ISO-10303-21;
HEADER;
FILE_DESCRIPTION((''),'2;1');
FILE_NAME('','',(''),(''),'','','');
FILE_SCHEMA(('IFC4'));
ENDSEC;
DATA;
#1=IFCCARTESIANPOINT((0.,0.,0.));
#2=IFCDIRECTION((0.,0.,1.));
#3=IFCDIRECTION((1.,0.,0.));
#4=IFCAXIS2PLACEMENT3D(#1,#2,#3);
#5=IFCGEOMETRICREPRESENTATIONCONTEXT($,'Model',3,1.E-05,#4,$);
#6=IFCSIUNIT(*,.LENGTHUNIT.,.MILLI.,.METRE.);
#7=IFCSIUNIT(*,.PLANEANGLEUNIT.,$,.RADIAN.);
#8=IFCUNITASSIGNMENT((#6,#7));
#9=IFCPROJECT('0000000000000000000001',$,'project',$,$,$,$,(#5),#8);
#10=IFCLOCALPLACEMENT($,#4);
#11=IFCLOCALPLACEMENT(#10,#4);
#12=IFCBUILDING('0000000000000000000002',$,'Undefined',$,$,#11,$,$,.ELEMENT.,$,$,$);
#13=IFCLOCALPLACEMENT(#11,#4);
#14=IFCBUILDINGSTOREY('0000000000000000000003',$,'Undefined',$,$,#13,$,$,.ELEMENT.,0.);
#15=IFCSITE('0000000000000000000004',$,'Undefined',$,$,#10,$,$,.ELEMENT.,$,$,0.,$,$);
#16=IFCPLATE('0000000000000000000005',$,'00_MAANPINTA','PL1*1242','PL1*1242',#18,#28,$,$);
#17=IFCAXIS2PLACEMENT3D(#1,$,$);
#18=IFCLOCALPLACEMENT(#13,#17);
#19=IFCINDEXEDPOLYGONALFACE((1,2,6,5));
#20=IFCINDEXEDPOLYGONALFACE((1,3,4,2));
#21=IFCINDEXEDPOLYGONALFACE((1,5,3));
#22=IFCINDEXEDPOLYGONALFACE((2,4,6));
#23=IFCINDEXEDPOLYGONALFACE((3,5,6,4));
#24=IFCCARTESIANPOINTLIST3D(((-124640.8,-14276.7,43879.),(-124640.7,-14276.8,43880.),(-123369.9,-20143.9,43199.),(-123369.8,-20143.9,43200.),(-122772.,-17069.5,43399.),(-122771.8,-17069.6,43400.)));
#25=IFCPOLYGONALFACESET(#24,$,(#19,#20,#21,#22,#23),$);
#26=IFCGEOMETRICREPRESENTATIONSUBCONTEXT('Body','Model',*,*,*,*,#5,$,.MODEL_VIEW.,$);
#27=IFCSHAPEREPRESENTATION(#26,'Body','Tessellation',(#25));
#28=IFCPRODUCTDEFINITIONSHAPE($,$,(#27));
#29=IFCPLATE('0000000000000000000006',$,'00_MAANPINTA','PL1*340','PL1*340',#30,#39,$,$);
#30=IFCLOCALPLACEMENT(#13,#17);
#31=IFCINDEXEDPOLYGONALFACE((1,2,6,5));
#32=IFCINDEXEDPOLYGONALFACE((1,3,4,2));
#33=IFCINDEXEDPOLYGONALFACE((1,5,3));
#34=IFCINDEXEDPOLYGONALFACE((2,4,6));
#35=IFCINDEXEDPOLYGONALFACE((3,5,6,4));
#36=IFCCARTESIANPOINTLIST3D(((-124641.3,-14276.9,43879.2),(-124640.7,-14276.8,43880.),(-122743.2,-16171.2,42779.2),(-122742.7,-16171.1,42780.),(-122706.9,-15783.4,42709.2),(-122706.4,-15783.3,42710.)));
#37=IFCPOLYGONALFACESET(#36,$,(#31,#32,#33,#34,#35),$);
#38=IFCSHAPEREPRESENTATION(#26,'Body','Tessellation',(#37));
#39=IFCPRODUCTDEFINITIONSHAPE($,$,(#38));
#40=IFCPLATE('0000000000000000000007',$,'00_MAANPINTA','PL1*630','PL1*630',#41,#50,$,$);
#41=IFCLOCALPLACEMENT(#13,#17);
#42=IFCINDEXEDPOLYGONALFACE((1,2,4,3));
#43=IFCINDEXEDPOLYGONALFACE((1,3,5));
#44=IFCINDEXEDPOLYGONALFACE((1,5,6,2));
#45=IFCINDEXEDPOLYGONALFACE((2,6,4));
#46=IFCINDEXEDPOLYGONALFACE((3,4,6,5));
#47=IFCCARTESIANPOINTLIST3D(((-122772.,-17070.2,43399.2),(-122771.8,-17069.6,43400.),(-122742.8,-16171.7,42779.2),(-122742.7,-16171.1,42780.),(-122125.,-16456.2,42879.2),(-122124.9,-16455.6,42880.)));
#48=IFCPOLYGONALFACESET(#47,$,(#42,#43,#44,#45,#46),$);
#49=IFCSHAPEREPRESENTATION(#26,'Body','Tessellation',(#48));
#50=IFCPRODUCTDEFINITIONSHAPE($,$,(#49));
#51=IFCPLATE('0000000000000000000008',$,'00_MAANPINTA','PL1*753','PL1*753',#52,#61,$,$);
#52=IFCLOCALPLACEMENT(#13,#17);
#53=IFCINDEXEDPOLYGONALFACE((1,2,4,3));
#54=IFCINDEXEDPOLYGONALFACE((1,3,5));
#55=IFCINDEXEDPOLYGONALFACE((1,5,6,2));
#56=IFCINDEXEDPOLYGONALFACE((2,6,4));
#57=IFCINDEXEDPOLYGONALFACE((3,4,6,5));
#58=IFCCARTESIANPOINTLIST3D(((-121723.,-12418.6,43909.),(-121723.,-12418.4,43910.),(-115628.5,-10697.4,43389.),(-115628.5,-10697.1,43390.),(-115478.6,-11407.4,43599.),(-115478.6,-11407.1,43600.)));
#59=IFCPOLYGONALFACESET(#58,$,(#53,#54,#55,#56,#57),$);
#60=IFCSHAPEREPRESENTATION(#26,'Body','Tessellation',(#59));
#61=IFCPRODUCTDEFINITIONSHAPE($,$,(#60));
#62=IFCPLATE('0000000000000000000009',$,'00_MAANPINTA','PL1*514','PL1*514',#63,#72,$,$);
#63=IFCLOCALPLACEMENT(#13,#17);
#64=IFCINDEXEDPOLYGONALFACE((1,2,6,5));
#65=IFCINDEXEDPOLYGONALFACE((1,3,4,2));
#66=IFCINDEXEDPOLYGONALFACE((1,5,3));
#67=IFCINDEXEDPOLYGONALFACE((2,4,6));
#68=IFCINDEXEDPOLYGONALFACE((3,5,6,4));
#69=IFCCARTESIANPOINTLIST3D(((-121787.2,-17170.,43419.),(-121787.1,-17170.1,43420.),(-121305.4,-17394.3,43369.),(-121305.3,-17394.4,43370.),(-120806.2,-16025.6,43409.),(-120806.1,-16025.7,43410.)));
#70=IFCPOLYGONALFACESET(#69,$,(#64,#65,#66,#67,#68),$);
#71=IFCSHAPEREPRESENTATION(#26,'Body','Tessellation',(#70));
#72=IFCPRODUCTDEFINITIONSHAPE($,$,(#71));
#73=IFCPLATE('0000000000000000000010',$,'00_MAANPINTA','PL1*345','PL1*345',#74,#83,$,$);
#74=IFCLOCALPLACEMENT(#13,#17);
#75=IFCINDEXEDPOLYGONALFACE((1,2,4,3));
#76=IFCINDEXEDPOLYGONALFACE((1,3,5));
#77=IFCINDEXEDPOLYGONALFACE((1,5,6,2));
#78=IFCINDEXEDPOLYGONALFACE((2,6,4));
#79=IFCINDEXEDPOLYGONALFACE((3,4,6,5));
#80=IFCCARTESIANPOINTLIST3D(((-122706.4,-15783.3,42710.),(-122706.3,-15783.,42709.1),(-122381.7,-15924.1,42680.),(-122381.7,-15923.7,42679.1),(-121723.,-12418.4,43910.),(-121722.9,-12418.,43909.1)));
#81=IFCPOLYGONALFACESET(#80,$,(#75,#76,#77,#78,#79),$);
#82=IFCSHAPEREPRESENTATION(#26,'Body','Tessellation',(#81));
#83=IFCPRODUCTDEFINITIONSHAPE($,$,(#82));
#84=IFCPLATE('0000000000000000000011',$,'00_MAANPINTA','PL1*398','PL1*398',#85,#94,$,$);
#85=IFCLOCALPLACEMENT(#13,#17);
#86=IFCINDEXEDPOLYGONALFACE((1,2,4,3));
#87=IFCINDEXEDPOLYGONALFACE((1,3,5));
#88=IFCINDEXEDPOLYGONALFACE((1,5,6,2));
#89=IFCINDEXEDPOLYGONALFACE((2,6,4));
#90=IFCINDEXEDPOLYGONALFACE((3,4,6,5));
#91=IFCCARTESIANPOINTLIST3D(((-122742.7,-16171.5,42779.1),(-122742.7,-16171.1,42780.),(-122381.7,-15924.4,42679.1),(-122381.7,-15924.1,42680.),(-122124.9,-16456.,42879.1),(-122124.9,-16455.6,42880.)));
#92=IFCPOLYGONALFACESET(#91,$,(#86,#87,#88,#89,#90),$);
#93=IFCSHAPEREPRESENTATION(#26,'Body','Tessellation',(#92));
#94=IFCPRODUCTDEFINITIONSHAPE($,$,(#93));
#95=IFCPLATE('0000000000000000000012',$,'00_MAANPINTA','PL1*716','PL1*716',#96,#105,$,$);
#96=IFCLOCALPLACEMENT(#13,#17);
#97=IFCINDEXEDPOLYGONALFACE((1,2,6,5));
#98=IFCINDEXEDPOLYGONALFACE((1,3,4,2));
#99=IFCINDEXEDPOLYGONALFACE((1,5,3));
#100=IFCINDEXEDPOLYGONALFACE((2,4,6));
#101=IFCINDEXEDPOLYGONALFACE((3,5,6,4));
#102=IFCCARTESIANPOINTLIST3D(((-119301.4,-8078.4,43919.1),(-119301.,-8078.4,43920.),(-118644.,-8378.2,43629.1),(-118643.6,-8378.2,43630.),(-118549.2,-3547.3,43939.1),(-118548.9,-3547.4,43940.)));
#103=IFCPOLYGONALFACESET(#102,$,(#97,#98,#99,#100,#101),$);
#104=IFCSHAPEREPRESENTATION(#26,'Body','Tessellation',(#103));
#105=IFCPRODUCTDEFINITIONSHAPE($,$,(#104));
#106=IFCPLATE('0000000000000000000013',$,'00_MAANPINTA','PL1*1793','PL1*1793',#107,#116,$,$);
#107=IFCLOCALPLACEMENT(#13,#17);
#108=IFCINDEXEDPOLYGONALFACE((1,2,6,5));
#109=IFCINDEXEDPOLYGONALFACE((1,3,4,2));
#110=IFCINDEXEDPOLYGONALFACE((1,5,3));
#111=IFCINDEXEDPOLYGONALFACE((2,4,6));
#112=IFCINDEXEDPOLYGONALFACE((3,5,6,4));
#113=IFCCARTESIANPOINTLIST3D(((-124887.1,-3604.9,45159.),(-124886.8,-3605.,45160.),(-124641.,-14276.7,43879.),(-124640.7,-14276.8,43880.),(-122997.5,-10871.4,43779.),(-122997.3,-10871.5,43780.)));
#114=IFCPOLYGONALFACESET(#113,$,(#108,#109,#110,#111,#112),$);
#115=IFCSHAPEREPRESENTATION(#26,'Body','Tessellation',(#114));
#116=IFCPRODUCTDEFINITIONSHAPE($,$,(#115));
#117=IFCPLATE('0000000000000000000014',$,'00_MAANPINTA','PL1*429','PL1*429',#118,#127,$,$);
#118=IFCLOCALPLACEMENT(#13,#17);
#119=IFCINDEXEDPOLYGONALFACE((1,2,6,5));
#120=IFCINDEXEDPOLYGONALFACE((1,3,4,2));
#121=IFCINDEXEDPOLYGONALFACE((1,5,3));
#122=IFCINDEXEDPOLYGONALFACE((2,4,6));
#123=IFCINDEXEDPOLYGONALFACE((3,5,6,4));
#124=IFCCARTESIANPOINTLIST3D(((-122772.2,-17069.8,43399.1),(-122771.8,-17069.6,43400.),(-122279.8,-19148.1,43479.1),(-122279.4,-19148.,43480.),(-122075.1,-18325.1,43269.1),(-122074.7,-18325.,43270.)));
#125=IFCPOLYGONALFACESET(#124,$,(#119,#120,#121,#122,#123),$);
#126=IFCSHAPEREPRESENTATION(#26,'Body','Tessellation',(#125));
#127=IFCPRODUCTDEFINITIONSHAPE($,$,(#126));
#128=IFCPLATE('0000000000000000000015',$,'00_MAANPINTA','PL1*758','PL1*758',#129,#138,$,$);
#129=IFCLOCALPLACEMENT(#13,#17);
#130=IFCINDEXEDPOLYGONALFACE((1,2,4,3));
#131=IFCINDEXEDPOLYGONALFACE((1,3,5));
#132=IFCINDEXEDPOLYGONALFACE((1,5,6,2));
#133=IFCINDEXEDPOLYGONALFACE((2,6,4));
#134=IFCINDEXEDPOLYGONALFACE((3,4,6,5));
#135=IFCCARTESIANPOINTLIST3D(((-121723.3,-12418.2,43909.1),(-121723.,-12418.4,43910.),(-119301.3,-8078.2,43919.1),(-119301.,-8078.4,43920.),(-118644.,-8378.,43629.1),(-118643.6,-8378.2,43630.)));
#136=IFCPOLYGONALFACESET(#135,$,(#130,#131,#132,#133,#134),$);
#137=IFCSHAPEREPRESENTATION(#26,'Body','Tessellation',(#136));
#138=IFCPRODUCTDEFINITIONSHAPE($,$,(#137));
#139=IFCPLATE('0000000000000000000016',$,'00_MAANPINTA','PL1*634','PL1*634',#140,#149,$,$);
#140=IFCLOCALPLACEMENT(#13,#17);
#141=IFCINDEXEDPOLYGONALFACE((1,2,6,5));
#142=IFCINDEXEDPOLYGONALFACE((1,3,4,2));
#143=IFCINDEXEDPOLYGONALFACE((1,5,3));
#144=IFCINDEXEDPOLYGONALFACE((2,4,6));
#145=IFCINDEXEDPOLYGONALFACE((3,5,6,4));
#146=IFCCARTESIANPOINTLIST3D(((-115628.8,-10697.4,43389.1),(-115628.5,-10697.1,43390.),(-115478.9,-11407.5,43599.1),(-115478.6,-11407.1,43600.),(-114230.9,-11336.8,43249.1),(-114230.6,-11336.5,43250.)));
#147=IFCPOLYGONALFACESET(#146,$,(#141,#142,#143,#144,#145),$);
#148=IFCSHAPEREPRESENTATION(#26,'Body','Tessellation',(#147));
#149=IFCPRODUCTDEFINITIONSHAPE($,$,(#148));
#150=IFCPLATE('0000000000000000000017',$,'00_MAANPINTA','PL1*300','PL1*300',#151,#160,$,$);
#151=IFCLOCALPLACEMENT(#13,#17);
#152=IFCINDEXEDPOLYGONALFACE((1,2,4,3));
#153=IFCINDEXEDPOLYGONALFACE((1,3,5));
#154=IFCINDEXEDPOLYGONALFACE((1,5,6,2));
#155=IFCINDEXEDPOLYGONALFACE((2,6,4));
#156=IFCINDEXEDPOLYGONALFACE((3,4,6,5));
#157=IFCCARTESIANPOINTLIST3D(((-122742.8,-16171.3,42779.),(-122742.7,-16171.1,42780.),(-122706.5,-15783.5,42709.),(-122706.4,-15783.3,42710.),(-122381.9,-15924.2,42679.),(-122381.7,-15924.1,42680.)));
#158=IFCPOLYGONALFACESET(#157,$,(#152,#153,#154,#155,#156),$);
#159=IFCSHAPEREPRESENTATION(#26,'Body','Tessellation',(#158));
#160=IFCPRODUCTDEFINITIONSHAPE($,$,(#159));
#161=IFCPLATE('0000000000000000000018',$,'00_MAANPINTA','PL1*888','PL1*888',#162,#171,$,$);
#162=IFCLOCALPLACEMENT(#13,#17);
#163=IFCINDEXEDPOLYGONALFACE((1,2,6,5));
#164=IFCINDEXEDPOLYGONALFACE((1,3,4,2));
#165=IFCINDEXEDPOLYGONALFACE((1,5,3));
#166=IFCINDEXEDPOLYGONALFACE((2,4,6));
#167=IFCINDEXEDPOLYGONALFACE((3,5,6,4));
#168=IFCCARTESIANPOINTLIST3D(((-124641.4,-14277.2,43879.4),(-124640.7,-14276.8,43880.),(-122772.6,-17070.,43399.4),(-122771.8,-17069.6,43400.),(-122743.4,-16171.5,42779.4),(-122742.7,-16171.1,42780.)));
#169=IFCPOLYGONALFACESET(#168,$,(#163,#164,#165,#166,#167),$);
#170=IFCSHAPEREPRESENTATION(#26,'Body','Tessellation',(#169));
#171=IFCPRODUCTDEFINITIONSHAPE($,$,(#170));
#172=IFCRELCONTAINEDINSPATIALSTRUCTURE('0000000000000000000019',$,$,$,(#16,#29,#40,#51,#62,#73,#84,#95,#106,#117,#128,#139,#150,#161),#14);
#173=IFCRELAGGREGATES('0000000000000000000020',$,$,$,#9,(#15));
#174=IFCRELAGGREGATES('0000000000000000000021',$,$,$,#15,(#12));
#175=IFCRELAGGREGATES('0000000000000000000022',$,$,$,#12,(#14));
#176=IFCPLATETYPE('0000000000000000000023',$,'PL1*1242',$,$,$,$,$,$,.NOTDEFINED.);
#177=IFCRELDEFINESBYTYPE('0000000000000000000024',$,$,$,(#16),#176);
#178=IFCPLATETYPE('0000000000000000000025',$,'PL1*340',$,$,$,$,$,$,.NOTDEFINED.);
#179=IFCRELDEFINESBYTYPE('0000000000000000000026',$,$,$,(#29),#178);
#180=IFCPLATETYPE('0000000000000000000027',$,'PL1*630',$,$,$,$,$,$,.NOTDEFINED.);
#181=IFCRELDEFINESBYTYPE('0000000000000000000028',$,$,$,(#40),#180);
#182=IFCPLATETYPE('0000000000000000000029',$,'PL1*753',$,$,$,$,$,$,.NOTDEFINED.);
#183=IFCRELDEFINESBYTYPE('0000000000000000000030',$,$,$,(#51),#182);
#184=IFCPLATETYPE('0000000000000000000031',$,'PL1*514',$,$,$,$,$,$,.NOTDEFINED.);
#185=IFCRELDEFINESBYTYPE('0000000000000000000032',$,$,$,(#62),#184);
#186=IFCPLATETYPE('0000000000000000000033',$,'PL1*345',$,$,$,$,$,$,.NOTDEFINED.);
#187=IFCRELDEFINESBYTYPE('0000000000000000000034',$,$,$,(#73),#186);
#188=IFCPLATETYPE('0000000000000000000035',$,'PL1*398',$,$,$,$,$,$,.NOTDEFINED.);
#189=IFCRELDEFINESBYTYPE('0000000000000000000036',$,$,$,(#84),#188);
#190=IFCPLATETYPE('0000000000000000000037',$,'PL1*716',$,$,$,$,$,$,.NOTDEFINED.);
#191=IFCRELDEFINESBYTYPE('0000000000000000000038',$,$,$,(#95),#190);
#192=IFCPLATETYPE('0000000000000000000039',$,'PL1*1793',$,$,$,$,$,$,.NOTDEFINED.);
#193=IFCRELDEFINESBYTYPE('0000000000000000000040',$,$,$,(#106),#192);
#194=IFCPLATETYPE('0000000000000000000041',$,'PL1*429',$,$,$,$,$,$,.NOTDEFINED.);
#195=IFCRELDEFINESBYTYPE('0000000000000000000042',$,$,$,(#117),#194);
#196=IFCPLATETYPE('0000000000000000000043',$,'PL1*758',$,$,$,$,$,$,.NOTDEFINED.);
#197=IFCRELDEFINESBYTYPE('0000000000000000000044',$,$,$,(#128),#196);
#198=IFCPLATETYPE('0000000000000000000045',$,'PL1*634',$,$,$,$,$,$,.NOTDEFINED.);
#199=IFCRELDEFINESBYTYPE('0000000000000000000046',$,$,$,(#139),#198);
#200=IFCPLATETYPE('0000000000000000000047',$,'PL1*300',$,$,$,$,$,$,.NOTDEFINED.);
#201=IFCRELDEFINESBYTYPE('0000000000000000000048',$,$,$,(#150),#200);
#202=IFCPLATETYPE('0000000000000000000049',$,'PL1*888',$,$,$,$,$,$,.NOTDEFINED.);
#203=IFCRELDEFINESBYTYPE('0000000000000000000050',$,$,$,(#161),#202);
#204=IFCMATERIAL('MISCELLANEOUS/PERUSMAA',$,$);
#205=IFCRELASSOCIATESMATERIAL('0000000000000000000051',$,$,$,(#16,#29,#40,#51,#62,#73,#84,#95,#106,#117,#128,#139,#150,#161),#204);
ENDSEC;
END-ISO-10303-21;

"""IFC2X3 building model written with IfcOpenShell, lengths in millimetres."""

from ifc_helpers import new_model, si_unit, frame, origin_with_axes, place, context, subcontext, project, spatial, polyline, outline, extrude, material, type_object, element, save


model = new_model("IFC2X3")

# Units and contexts
model_context = context("Model", 3, precision=1e-05, world=origin_with_axes())
body_context = subcontext(model_context, "Body", "Model", "MODEL_VIEW")
ifc_project = project(units=[si_unit("LENGTHUNIT", "METRE", prefix="MILLI"), si_unit("PLANEANGLEUNIT", "RADIAN")], contexts=[model_context])

# Site, building, storey
site_placement = place(None, origin_with_axes())
site = spatial("IfcSite", under=ifc_project, at=site_placement, Name="Undefined", CompositionType="ELEMENT", RefElevation=0.0)
building_placement = place(site_placement, origin_with_axes())
building = spatial("IfcBuilding", under=site, at=building_placement, Name="Undefined", CompositionType="ELEMENT")
storey_placement = place(building_placement, origin_with_axes())
storey = spatial("IfcBuildingStorey", under=building, at=storey_placement, Name="Undefined", CompositionType="ELEMENT", Elevation=0.0)

# Plates
ifc_material = material(Name="MISCELLANEOUS/PERUSMAA")
plate_type_1 = type_object("IfcPlateType", Name="PL1*1242", PredefinedType="NOTDEFINED")
plate_1_placement = place(storey_placement, frame((-122771.9, -17069.6, 43399.5), z_axis=(-0.122262, 0.088093, -0.988581), x_axis=(-0.190543, -0.979608, -0.063729)))
element("IfcPlate", 1, at=plate_1_placement, inside=storey, type_object=plate_type_1, material=ifc_material, Name="00_MAANPINTA", Description="PL1*1242", ObjectType="PL1*1242", context=body_context, shape_type="SweptSolid", body=[
    extrude(outline(polyline([(0.0, 0.0), (3138.3, 0.0), (-2410.4, 2390.2), (0.0, 0.0)])), frame((0.0, 0.0, -0.5), z_axis=(0.0, 0.0, 1.0), x_axis=(1.0, 0.0, 0.0)), (0.0, 0.0, 1.0), 1.0),
])
plate_type_2 = type_object("IfcPlateType", Name="PL1*340", PredefinedType="NOTDEFINED")
plate_2_placement = place(storey_placement, frame((-124641.0, -14276.8, 43879.6), z_axis=(-0.568042, -0.094408, -0.817567), x_axis=(0.712031, -0.554551, -0.43068)))
element("IfcPlate", 2, at=plate_2_placement, inside=storey, type_object=plate_type_2, material=ifc_material, Name="00_MAANPINTA", Description="PL1*340", ObjectType="PL1*340", context=body_context, shape_type="SweptSolid", body=[
    extrude(outline(polyline([(0.0, 0.0), (2716.6, 0.0), (2875.7, 362.4), (0.0, 0.0)])), frame((0.0, 0.0, -0.5), z_axis=(0.0, 0.0, 1.0), x_axis=(1.0, 0.0, 0.0)), (0.0, 0.0, 1.0), 1.0),
])
plate_type_3 = type_object("IfcPlateType", Name="PL1*630", PredefinedType="NOTDEFINED")
plate_3_placement = place(storey_placement, frame((-122771.9, -17069.9, 43399.6), z_axis=(-0.125708, -0.560662, -0.818447), x_axis=(0.026719, 0.822779, -0.567733)))
element("IfcPlate", 3, at=plate_3_placement, inside=storey, type_object=plate_type_3, material=ifc_material, Name="00_MAANPINTA", Description="PL1*630", ObjectType="PL1*630", context=body_context, shape_type="SweptSolid", body=[
    extrude(outline(polyline([(0.0, 0.0), (1092.1, 0.0), (817.7, 630.3), (0.0, 0.0)])), frame((0.0, 0.0, -0.5), z_axis=(0.0, 0.0, 1.0), x_axis=(1.0, 0.0, 0.0)), (0.0, 0.0, 1.0), 1.0),
])
plate_type_4 = type_object("IfcPlateType", Name="PL1*753", PredefinedType="NOTDEFINED")
plate_4_placement = place(storey_placement, frame((-115628.5, -10697.3, 43389.5), z_axis=(-0.001621, -0.283934, -0.958842), x_axis=(0.198416, -0.939871, 0.277981)))
element("IfcPlate", 4, at=plate_4_placement, inside=storey, type_object=plate_type_4, material=ifc_material, Name="00_MAANPINTA", Description="PL1*753", ObjectType="PL1*753", context=body_context, shape_type="SweptSolid", body=[
    extrude(outline(polyline([(0.0, 0.0), (755.4, 0.0), (553.1, 6330.1), (0.0, 0.0)])), frame((0.0, 0.0, -0.5), z_axis=(0.0, 0.0, 1.0), x_axis=(1.0, 0.0, 0.0)), (0.0, 0.0, 1.0), 1.0),
])
plate_type_5 = type_object("IfcPlateType", Name="PL1*514", PredefinedType="NOTDEFINED")
plate_5_placement = place(storey_placement, frame((-120806.1, -16025.6, 43409.5), z_axis=(-0.076722, 0.057072, -0.995418), x_axis=(-0.342508, -0.939114, -0.027445)))
element("IfcPlate", 5, at=plate_5_placement, inside=storey, type_object=plate_type_5, material=ifc_material, Name="00_MAANPINTA", Description="PL1*514", ObjectType="PL1*514", context=body_context, shape_type="SweptSolid", body=[
    extrude(outline(polyline([(0.0, 0.0), (1457.5, 0.0), (1410.5, 531.8), (0.0, 0.0)])), frame((0.0, 0.0, -0.5), z_axis=(0.0, 0.0, 1.0), x_axis=(1.0, 0.0, 0.0)), (0.0, 0.0, 1.0), 1.0),
])
plate_type_6 = type_object("IfcPlateType", Name="PL1*345", PredefinedType="NOTDEFINED")
plate_6_placement = place(storey_placement, frame((-122381.7, -15923.9, 42679.5), z_axis=(0.052196, 0.321871, -0.945344), x_axis=(-0.914193, 0.396376, 0.084482)))
element("IfcPlate", 6, at=plate_6_placement, inside=storey, type_object=plate_type_6, material=ifc_material, Name="00_MAANPINTA", Description="PL1*345", ObjectType="PL1*345", context=body_context, shape_type="SweptSolid", body=[
    extrude(outline(polyline([(0.0, 0.0), (355.1, 0.0), (891.3, 3666.4), (0.0, 0.0)])), frame((0.0, 0.0, -0.5), z_axis=(0.0, 0.0, 1.0), x_axis=(1.0, 0.0, 0.0)), (0.0, 0.0, 1.0), 1.0),
])
plate_type_7 = type_object("IfcPlateType", Name="PL1*398", PredefinedType="NOTDEFINED")
plate_7_placement = place(storey_placement, frame((-122124.9, -16455.8, 42879.5), z_axis=(-0.013699, -0.357925, -0.93365), x_axis=(-0.898655, 0.413836, -0.145463)))
element("IfcPlate", 7, at=plate_7_placement, inside=storey, type_object=plate_type_7, material=ifc_material, Name="00_MAANPINTA", Description="PL1*398", ObjectType="PL1*398", context=body_context, shape_type="SweptSolid", body=[
    extrude(outline(polyline([(0.0, 0.0), (687.5, 0.0), (479.9, 397.8), (0.0, 0.0)])), frame((0.0, 0.0, -0.5), z_axis=(0.0, 0.0, 1.0), x_axis=(1.0, 0.0, 0.0)), (0.0, 0.0, 1.0), 1.0),
])
plate_type_8 = type_object("IfcPlateType", Name="PL1*716", PredefinedType="NOTDEFINED")
plate_8_placement = place(storey_placement, frame((-118643.8, -8378.2, 43629.5), z_axis=(-0.377118, 0.066677, -0.923762), x_axis=(-0.844363, 0.385091, 0.3725)))
element("IfcPlate", 8, at=plate_8_placement, inside=storey, type_object=plate_type_8, material=ifc_material, Name="00_MAANPINTA", Description="PL1*716", ObjectType="PL1*716", context=body_context, shape_type="SweptSolid", body=[
    extrude(outline(polyline([(0.0, 0.0), (778.5, 0.0), (1895.8, 4455.1), (0.0, 0.0)])), frame((0.0, 0.0, -0.5), z_axis=(0.0, 0.0, 1.0), x_axis=(1.0, 0.0, 0.0)), (0.0, 0.0, 1.0), 1.0),
])
plate_type_9 = type_object("IfcPlateType", Name="PL1*1793", PredefinedType="NOTDEFINED")
plate_9_placement = place(storey_placement, frame((-124886.9, -3605.0, 45159.5), z_axis=(-0.28153, 0.10787, -0.95347), x_axis=(0.247516, -0.95187, -0.180772)))
element("IfcPlate", 9, at=plate_9_placement, inside=storey, type_object=plate_type_9, material=ifc_material, Name="00_MAANPINTA", Description="PL1*1793", ObjectType="PL1*1793", context=body_context, shape_type="SweptSolid", body=[
    extrude(outline(polyline([(0.0, 0.0), (7633.9, 0.0), (10450.5, 2524.7), (0.0, 0.0)])), frame((0.0, 0.0, -0.5), z_axis=(0.0, 0.0, 1.0), x_axis=(1.0, 0.0, 0.0)), (0.0, 0.0, 1.0), 1.0),
])
plate_type_10 = type_object("IfcPlateType", Name="PL1*429", PredefinedType="NOTDEFINED")
plate_10_placement = place(storey_placement, frame((-122772.0, -17069.7, 43399.5), z_axis=(-0.403949, -0.130558, -0.905417), x_axis=(0.48351, -0.870682, -0.090167)))
element("IfcPlate", 10, at=plate_10_placement, inside=storey, type_object=plate_type_10, material=ifc_material, Name="00_MAANPINTA", Description="PL1*429", ObjectType="PL1*429", context=body_context, shape_type="SweptSolid", body=[
    extrude(outline(polyline([(0.0, 0.0), (1441.8, 0.0), (2040.5, 636.4), (0.0, 0.0)])), frame((0.0, 0.0, -0.5), z_axis=(0.0, 0.0, 1.0), x_axis=(1.0, 0.0, 0.0)), (0.0, 0.0, 1.0), 1.0),
])
plate_type_11 = type_object("IfcPlateType", Name="PL1*758", PredefinedType="NOTDEFINED")
plate_11_placement = place(storey_placement, frame((-121723.2, -12418.3, 43909.5), z_axis=(-0.325402, 0.183736, -0.927553), x_axis=(0.487323, 0.87322, 0.002012)))
element("IfcPlate", 11, at=plate_11_placement, inside=storey, type_object=plate_type_11, material=ifc_material, Name="00_MAANPINTA", Description="PL1*758", ObjectType="PL1*758", context=body_context, shape_type="SweptSolid", body=[
    extrude(outline(polyline([(0.0, 0.0), (4970.0, 0.0), (5028.0, 776.4), (0.0, 0.0)])), frame((0.0, 0.0, -0.5), z_axis=(0.0, 0.0, 1.0), x_axis=(1.0, 0.0, 0.0)), (0.0, 0.0, 1.0), 1.0),
])
plate_type_12 = type_object("IfcPlateType", Name="PL1*634", PredefinedType="NOTDEFINED")
plate_12_placement = place(storey_placement, frame((-115478.8, -11407.3, 43599.5), z_axis=(-0.238786, -0.321429, -0.916332), x_axis=(-0.198416, 0.939871, -0.277981)))
element("IfcPlate", 12, at=plate_12_placement, inside=storey, type_object=plate_type_12, material=ifc_material, Name="00_MAANPINTA", Description="PL1*634", ObjectType="PL1*634", context=body_context, shape_type="SweptSolid", body=[
    extrude(outline(polyline([(0.0, 0.0), (755.4, 0.0), (-83.9, 1295.4), (0.0, 0.0)])), frame((0.0, 0.0, -0.5), z_axis=(0.0, 0.0, 1.0), x_axis=(1.0, 0.0, 0.0)), (0.0, 0.0, 1.0), 1.0),
])
plate_type_13 = type_object("IfcPlateType", Name="PL1*300", PredefinedType="NOTDEFINED")
plate_13_placement = place(storey_placement, frame((-122381.8, -15924.1, 42679.5), z_axis=(-0.15975, -0.160856, -0.973964), x_axis=(-0.804462, -0.550603, 0.222884)))
element("IfcPlate", 13, at=plate_13_placement, inside=storey, type_object=plate_type_13, material=ifc_material, Name="00_MAANPINTA", Description="PL1*300", ObjectType="PL1*300", context=body_context, shape_type="SweptSolid", body=[
    extrude(outline(polyline([(0.0, 0.0), (448.7, 0.0), (190.3, 299.8), (0.0, 0.0)])), frame((0.0, 0.0, -0.5), z_axis=(0.0, 0.0, 1.0), x_axis=(1.0, 0.0, 0.0)), (0.0, 0.0, 1.0), 1.0),
])
plate_type_14 = type_object("IfcPlateType", Name="PL1*888", PredefinedType="NOTDEFINED")
plate_14_placement = place(storey_placement, frame((-124641.0, -14277.0, 43879.7), z_axis=(-0.71744, -0.379703, -0.584043), x_axis=(0.654847, -0.653562, -0.379516)))
element("IfcPlate", 14, at=plate_14_placement, inside=storey, type_object=plate_type_14, material=ifc_material, Name="00_MAANPINTA", Description="PL1*888", ObjectType="PL1*888", context=body_context, shape_type="SweptSolid", body=[
    extrude(outline(polyline([(0.0, 0.0), (2898.4, 0.0), (3231.3, 1040.1), (0.0, 0.0)])), frame((0.0, 0.0, -0.5), z_axis=(0.0, 0.0, 1.0), x_axis=(1.0, 0.0, 0.0)), (0.0, 0.0, 1.0), 1.0),
])

save(model, "model.ifc")
